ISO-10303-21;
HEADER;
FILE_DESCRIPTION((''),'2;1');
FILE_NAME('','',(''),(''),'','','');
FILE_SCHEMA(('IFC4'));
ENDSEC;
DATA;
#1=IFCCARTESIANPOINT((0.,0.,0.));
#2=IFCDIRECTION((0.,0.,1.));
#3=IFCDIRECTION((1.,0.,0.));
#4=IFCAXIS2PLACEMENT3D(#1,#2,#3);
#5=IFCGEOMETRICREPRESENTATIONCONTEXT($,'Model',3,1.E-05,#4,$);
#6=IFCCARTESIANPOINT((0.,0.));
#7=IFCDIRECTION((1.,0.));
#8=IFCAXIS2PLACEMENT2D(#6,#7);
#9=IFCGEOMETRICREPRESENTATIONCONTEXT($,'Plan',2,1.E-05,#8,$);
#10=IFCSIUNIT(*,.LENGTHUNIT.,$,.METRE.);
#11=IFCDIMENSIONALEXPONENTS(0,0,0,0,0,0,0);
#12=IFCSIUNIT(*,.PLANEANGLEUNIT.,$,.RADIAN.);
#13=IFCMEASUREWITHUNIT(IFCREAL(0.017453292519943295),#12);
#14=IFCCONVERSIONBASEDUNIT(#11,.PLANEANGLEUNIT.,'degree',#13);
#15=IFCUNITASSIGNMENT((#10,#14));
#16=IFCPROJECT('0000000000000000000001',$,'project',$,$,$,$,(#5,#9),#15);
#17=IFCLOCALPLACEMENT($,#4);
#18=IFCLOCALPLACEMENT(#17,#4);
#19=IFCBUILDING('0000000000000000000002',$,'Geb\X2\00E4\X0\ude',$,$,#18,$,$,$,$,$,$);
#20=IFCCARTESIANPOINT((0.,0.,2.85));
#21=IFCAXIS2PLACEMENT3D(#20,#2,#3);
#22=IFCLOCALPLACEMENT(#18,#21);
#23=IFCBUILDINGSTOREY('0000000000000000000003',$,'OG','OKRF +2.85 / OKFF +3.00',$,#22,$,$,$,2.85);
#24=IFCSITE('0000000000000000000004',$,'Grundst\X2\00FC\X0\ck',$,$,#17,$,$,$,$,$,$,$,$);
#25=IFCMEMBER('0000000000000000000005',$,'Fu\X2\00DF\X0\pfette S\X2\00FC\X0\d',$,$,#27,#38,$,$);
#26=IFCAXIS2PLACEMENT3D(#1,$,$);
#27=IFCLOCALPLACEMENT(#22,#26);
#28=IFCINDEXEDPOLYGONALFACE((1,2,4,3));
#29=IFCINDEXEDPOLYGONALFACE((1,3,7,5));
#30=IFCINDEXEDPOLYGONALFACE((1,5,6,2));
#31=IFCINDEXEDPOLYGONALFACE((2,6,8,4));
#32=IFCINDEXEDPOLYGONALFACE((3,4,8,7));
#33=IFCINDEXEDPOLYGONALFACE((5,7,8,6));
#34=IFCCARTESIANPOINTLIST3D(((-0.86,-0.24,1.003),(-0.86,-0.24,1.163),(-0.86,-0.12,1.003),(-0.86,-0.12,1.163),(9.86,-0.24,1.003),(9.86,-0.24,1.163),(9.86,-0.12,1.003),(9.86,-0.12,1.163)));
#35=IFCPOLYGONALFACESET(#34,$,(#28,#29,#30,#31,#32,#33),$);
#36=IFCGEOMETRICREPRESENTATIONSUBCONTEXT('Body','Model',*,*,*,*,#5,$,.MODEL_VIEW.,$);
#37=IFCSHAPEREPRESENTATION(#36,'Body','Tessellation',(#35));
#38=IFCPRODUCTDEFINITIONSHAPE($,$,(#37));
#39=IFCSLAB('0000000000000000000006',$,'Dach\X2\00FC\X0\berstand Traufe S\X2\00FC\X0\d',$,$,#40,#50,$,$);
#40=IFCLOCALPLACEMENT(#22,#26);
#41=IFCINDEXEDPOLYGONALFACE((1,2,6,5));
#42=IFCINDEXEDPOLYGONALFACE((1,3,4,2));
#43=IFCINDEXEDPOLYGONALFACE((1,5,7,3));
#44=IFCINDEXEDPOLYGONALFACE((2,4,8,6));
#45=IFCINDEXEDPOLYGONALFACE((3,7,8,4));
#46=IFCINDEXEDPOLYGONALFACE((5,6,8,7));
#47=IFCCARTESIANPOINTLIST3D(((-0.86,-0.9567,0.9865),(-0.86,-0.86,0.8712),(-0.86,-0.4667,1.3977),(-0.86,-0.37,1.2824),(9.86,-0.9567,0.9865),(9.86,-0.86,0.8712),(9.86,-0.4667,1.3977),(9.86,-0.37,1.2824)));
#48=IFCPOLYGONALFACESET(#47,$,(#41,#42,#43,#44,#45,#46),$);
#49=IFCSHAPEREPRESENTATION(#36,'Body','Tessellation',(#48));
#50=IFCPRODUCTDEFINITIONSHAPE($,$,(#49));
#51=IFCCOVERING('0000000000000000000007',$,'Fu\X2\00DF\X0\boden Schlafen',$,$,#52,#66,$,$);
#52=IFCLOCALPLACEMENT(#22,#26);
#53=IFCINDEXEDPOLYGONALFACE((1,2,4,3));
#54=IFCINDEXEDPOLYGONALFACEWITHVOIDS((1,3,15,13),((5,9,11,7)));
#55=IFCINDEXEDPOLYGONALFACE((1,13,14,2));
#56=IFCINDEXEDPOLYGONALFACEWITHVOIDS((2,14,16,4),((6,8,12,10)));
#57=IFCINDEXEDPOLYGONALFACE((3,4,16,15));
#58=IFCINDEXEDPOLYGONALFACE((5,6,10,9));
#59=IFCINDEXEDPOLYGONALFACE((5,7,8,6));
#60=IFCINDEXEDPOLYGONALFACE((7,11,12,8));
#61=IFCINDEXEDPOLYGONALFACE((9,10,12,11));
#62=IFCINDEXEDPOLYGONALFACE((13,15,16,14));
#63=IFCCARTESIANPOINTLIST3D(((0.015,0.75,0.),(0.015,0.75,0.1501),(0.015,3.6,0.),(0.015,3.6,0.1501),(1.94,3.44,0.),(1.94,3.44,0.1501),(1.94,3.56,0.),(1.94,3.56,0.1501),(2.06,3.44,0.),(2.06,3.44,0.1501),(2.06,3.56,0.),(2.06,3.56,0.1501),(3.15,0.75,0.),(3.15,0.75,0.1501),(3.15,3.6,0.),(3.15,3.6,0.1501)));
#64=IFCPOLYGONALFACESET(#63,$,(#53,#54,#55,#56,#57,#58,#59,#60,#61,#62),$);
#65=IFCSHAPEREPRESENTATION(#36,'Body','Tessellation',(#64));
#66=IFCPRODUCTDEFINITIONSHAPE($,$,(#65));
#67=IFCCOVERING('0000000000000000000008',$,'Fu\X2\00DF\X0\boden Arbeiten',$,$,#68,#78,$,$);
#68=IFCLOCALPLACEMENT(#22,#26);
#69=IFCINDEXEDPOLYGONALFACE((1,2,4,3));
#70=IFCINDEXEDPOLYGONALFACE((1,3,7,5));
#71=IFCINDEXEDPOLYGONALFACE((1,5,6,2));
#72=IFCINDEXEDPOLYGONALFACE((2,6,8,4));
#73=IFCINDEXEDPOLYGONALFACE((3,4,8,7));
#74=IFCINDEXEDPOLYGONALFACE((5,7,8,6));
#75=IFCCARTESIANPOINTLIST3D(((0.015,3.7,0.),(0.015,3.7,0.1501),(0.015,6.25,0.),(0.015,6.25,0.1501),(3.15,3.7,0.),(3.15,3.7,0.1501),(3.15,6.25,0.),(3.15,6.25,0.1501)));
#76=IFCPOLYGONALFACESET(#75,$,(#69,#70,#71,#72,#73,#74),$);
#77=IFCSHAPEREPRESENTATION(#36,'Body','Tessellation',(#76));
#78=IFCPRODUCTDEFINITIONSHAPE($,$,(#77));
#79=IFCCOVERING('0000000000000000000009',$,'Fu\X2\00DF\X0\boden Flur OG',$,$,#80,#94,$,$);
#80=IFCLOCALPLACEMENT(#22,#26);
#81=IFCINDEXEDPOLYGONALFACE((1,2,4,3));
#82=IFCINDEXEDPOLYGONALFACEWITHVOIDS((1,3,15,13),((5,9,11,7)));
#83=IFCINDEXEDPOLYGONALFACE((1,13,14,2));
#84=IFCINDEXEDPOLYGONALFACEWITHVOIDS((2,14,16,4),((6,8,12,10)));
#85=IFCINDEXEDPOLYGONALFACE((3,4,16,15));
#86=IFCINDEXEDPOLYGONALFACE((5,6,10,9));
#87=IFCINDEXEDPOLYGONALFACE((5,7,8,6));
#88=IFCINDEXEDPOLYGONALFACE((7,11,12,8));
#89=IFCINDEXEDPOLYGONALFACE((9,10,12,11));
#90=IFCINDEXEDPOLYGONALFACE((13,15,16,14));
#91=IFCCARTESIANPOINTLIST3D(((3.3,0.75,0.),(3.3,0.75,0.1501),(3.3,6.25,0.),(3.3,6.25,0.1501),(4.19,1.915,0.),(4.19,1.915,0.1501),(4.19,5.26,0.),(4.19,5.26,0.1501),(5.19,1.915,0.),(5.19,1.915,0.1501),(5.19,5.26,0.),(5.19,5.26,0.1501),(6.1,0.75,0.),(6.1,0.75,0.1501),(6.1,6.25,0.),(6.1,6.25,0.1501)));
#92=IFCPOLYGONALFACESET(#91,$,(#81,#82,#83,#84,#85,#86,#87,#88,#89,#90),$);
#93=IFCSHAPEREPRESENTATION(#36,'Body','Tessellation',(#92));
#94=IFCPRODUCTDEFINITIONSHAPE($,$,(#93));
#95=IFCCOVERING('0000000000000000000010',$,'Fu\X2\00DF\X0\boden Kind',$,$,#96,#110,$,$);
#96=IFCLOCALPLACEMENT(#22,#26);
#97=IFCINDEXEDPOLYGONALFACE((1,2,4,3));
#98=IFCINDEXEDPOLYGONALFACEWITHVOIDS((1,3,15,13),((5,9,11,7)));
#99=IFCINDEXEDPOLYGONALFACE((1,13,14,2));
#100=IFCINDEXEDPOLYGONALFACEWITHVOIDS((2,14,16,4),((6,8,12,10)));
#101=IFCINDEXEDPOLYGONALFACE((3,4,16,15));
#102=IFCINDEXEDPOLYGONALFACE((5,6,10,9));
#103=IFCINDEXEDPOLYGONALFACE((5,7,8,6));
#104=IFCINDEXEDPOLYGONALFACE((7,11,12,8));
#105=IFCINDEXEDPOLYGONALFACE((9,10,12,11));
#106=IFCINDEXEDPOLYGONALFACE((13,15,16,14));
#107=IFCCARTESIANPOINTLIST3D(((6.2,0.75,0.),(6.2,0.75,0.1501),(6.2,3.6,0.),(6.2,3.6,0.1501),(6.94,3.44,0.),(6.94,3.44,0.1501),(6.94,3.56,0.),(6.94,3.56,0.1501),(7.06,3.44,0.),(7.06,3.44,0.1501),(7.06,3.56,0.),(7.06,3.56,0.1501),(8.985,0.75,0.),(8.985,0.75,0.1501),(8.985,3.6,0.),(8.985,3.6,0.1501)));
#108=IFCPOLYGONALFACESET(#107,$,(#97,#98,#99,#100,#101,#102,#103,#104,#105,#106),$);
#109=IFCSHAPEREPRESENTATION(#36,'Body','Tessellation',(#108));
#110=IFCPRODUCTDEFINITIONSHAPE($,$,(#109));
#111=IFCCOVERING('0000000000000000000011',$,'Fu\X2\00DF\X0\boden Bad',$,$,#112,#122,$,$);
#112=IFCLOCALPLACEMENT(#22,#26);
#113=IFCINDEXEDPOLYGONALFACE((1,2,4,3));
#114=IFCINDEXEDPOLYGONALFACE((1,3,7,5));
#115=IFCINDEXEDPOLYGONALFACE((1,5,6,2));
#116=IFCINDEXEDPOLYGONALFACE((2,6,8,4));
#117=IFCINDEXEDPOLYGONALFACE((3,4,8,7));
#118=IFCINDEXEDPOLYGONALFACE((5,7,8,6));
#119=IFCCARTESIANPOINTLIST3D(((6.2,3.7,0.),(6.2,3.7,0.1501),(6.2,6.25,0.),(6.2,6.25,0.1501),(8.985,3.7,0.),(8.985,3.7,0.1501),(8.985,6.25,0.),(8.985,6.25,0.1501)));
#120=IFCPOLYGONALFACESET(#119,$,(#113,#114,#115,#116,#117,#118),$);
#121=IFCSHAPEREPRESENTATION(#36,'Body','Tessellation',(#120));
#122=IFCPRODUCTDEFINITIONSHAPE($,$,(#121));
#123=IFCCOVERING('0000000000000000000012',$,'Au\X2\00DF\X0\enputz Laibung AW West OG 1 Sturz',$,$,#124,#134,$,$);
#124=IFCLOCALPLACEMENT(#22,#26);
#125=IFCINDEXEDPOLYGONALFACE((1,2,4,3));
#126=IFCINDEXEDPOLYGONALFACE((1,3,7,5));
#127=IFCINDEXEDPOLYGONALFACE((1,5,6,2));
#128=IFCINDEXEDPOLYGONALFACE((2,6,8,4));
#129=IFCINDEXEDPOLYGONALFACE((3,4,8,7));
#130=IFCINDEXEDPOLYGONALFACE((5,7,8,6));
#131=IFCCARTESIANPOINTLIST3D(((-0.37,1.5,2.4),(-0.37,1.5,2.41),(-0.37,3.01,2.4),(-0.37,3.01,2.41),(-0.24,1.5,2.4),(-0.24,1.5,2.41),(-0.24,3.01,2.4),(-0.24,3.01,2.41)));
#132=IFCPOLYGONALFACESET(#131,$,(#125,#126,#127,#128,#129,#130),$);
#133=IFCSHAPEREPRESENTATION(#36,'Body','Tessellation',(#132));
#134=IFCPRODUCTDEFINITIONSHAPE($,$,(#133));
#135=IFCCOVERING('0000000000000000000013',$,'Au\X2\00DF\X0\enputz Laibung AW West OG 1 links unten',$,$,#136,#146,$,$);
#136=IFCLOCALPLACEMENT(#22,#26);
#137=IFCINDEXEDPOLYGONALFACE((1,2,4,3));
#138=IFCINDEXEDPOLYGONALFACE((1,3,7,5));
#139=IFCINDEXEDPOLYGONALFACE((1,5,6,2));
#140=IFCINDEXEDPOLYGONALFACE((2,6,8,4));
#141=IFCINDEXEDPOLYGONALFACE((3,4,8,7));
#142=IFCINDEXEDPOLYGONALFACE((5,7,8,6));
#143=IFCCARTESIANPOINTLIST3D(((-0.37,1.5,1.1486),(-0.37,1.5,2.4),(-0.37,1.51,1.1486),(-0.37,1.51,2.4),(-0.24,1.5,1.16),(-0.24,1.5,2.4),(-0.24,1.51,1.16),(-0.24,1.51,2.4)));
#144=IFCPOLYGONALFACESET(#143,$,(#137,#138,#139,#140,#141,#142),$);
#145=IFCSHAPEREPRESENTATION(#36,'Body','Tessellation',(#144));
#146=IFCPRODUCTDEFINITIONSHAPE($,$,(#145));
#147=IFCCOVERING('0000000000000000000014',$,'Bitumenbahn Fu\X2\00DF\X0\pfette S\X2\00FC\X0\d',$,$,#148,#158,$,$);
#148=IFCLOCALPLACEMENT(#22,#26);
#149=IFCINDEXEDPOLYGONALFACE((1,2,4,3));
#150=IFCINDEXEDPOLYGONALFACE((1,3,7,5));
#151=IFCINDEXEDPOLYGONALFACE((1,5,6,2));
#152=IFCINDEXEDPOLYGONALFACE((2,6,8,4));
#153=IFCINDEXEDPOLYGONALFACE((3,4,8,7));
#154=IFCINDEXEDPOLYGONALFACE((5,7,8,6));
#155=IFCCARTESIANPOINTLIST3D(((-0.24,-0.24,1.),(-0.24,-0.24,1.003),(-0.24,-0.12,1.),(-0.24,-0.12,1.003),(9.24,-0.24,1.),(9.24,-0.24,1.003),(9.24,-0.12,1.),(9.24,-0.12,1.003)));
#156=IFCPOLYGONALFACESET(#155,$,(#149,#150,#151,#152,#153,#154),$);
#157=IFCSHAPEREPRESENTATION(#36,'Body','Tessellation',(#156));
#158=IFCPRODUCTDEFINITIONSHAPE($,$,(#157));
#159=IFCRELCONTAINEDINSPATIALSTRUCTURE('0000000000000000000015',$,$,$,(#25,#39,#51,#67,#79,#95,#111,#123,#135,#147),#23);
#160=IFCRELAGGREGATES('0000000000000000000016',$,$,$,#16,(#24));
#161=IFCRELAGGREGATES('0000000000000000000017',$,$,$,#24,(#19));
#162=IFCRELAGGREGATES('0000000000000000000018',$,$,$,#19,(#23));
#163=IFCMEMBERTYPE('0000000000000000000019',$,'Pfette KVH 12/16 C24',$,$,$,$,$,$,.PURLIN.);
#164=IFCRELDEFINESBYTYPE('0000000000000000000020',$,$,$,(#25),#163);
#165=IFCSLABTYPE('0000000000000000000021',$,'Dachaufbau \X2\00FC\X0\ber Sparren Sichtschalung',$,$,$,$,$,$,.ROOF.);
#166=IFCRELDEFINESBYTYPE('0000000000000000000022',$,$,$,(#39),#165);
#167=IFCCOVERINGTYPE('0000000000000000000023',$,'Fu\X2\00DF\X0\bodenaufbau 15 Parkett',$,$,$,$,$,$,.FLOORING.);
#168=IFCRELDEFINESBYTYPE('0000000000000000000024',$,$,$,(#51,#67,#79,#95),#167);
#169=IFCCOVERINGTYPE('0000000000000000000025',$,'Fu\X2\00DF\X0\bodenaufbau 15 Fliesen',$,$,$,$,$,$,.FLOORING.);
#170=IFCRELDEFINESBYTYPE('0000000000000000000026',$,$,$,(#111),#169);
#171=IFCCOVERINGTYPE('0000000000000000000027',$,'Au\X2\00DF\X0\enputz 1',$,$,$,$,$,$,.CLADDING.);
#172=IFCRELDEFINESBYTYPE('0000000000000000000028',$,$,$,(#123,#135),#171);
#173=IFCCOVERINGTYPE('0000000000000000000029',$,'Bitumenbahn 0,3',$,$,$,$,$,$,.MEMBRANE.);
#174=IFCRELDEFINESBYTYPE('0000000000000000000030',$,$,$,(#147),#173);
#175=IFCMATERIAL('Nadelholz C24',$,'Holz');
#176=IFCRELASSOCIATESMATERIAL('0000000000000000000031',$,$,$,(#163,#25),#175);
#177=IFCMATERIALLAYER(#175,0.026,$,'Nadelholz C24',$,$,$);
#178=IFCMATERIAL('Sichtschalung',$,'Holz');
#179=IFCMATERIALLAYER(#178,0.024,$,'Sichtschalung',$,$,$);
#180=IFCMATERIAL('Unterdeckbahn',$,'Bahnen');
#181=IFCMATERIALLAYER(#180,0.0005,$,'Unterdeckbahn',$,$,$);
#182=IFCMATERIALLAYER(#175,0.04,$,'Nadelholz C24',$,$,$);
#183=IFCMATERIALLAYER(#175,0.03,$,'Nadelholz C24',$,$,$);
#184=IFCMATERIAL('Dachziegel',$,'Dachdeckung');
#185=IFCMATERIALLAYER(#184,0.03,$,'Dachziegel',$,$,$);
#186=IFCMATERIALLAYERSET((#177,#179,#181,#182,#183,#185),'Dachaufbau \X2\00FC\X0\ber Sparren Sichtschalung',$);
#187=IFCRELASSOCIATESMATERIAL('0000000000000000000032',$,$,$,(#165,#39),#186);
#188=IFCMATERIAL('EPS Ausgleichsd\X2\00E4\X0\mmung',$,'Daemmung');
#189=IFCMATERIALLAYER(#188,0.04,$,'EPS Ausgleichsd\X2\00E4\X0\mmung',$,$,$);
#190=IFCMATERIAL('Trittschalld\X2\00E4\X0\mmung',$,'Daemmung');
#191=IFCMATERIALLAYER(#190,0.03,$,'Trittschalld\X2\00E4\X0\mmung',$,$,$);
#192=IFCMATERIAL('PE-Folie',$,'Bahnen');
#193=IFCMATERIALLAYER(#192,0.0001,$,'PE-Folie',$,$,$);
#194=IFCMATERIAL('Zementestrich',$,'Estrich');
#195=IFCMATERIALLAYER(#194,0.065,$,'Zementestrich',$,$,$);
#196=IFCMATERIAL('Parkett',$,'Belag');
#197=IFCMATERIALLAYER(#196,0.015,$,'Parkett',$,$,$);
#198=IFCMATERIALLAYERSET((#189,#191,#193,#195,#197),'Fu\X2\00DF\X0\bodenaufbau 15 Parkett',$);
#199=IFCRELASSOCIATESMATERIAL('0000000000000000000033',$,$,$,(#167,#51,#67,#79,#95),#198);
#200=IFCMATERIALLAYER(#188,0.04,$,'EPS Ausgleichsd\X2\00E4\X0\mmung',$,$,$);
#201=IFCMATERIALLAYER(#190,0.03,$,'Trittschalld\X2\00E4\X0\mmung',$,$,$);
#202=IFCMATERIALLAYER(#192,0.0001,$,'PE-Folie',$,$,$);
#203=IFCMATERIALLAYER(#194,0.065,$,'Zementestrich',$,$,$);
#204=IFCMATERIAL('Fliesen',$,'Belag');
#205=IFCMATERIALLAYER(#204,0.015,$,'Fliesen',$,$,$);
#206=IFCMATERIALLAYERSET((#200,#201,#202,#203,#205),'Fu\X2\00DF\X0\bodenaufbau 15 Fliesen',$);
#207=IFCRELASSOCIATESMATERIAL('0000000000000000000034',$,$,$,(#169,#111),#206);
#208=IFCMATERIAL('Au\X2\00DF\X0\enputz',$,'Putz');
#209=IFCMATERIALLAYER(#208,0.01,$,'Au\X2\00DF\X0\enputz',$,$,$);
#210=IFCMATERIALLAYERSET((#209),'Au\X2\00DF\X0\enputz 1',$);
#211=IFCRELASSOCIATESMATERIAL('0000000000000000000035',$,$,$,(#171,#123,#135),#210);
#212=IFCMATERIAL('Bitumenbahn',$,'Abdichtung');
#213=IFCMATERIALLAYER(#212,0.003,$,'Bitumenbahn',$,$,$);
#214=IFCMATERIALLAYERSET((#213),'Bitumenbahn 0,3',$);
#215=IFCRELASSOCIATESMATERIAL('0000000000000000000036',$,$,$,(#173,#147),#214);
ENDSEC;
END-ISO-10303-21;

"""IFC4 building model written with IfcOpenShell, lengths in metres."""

from ifc_helpers import new_model, entity, si_unit, converted_unit, frame, origin_with_axes, origin_2d_with_axis, place, context, subcontext, project, spatial, polyline, indexed_curve, rectangle, outline, extrude, clip, halfspace, material, layer, layer_set, layer_usage, material_profile, profile_set, profile_usage, type_object, element, save


model = new_model("IFC4")

# Units and contexts
model_context = context("Model", 3, precision=1e-05, world=origin_with_axes())
plan_context = context("Plan", 2, precision=1e-05, world=origin_2d_with_axis())
body_context_1 = subcontext(model_context, "Body", "Model", "MODEL_VIEW")
ifc_project = project(units=[si_unit("LENGTHUNIT", "METRE"), converted_unit("PLANEANGLEUNIT", "degree", entity("IfcReal", 0.017453292519943295), si_unit("PLANEANGLEUNIT", "RADIAN"), dimensions=[0, 0, 0, 0, 0, 0, 0])], contexts=[model_context, plan_context])

# Site, building, storey
site_placement = place(None, origin_with_axes())
site = spatial("IfcSite", under=ifc_project, at=site_placement, Name="Grundstück")
building_placement = place(site_placement, origin_with_axes())
building = spatial("IfcBuilding", under=site, at=building_placement, Name="Gebäude")
storey_placement = place(building_placement, frame((0.0, 0.0, 2.85), z_axis=(0.0, 0.0, 1.0), x_axis=(1.0, 0.0, 0.0)))
storey = spatial("IfcBuildingStorey", under=building, at=storey_placement, Name="OG", Description="OKRF +2.85 / OKFF +3.00", Elevation=2.85)

# Shared definitions
ifc_material_1 = material(Name="Nadelholz C24", Category="Holz")

# Member
ifc_material_profile_1 = material_profile(ifc_material_1, rectangle(XDim=0.12, YDim=0.16))
ifc_profile_set_1 = profile_set([ifc_material_profile_1], Name="Pfette KVH 12/16 C24")
ifc_profile_usage_1 = profile_usage(ifc_profile_set_1)
member_type_1 = type_object("IfcMemberType", Name="Pfette KVH 12/16 C24", PredefinedType="PURLIN", material=ifc_profile_set_1)
member_1_placement = place(storey_placement, frame((-0.86, -0.18, 1.083), z_axis=(1.0, 0.0, 0.0), x_axis=(0.0, 1.0, 0.0)))
element("IfcMember", 1, at=member_1_placement, inside=storey, type_object=member_type_1, material=ifc_profile_usage_1, Name="Fußpfette Süd", context=body_context_1, shape_type="SweptSolid", body=[
    extrude(rectangle(XDim=0.12, YDim=0.16), origin_with_axes(), (0.0, 0.0, 1.0), 10.72),
])

# Slab
ifc_material_2 = material(Name="Unterdeckbahn", Category="Bahnen")
ifc_material_3 = material(Name="Dachziegel", Category="Dachdeckung")
ifc_layer_1 = layer(ifc_material_1, 0.026, Name="Nadelholz C24")
ifc_material_4 = material(Name="Sichtschalung", Category="Holz")
ifc_layer_2 = layer(ifc_material_4, 0.024, Name="Sichtschalung")
ifc_layer_3 = layer(ifc_material_2, 0.0005, Name="Unterdeckbahn")
ifc_layer_4 = layer(ifc_material_1, 0.04, Name="Nadelholz C24")
ifc_layer_5 = layer(ifc_material_1, 0.03, Name="Nadelholz C24")
ifc_layer_6 = layer(ifc_material_3, 0.03, Name="Dachziegel")
ifc_layer_set_1 = layer_set([ifc_layer_1, ifc_layer_2, ifc_layer_3, ifc_layer_4, ifc_layer_5, ifc_layer_6], Name="Dachaufbau über Sparren Sichtschalung")
ifc_layer_usage_1 = layer_usage(ifc_layer_set_1, "AXIS3", "POSITIVE", 0.0)
slab_type_1 = type_object("IfcSlabType", Name="Dachaufbau über Sparren Sichtschalung", PredefinedType="ROOF", material=ifc_layer_set_1)
slab_1_placement = place(storey_placement, frame((-0.86, -0.86, 0.8712), z_axis=(0.0, -0.642788, 0.766044), x_axis=(1.0, 0.0, 0.0)))
element("IfcSlab", 2, at=slab_1_placement, inside=storey, type_object=slab_type_1, material=ifc_layer_usage_1, Name="Dachüberstand Traufe Süd", context=body_context_1, shape_type="Clipping", body=[
    clip(extrude(outline(indexed_curve([(0.0, 0.0), (10.72, 0.0), (10.72, 0.6396), (0.0, 0.6396)])), None, (0.0, 0.0, 1.0), 0.1505), halfspace(frame((0.86, 0.948, -5.6532), z_axis=(0.0, 0.766044, -0.642788), x_axis=(1.0, 0.0, 0.0)), False)),
])

# Covering, opening
ifc_material_5 = material(Name="EPS Ausgleichsdämmung", Category="Daemmung")
ifc_layer_7 = layer(ifc_material_5, 0.04, Name="EPS Ausgleichsdämmung")
ifc_material_6 = material(Name="Trittschalldämmung", Category="Daemmung")
ifc_layer_8 = layer(ifc_material_6, 0.03, Name="Trittschalldämmung")
ifc_material_7 = material(Name="PE-Folie", Category="Bahnen")
ifc_layer_9 = layer(ifc_material_7, 0.0001, Name="PE-Folie")
ifc_material_8 = material(Name="Zementestrich", Category="Estrich")
ifc_layer_10 = layer(ifc_material_8, 0.065, Name="Zementestrich")
ifc_material_9 = material(Name="Parkett", Category="Belag")
ifc_layer_11 = layer(ifc_material_9, 0.015, Name="Parkett")
ifc_layer_set_2 = layer_set([ifc_layer_7, ifc_layer_8, ifc_layer_9, ifc_layer_10, ifc_layer_11], Name="Fußbodenaufbau 15 Parkett")
ifc_layer_usage_2 = layer_usage(ifc_layer_set_2, "AXIS3", "POSITIVE", 0.0)
covering_type_1 = type_object("IfcCoveringType", Name="Fußbodenaufbau 15 Parkett", PredefinedType="FLOORING", material=ifc_layer_set_2)
covering_1_placement = place(storey_placement, origin_with_axes())
covering_1 = element("IfcCovering", 3, at=covering_1_placement, inside=storey, type_object=covering_type_1, material=ifc_layer_usage_2, Name="Fußboden Schlafen", context=body_context_1, shape_type="SweptSolid", body=[
    extrude(outline(indexed_curve([(0.015, 0.75), (3.15, 0.75), (3.15, 3.6), (0.015, 3.6)])), None, (0.0, 0.0, 1.0), 0.1501),
])
opening_1_placement = place(covering_1_placement, frame((1.94, 3.44, -0.05), z_axis=(0.0, 0.0, 1.0), x_axis=(1.0, 0.0, 0.0)))
element("IfcOpeningElement", 4, at=opening_1_placement, cuts=covering_1, context=body_context_1, shape_type="SweptSolid", body=[
    extrude(outline(indexed_curve([(0.0, 0.0), (0.0, 0.12), (0.12, 0.12), (0.12, 0.0), (0.0, 0.0)], self_intersect=False)), origin_with_axes(), (0.0, 0.0, 1.0), 0.2501),
])

# Covering
ifc_layer_usage_3 = layer_usage(ifc_layer_set_2, "AXIS3", "POSITIVE", 0.0)
covering_2_placement = place(storey_placement, origin_with_axes())
element("IfcCovering", 5, at=covering_2_placement, inside=storey, type_object=covering_type_1, material=ifc_layer_usage_3, Name="Fußboden Arbeiten", context=body_context_1, shape_type="SweptSolid", body=[
    extrude(outline(indexed_curve([(0.015, 3.7), (3.15, 3.7), (3.15, 6.25), (0.015, 6.25)])), None, (0.0, 0.0, 1.0), 0.1501),
])

# Coverings, openings
ifc_layer_usage_4 = layer_usage(ifc_layer_set_2, "AXIS3", "POSITIVE", 0.0)
covering_3_placement = place(storey_placement, origin_with_axes())
covering_3 = element("IfcCovering", 6, at=covering_3_placement, inside=storey, type_object=covering_type_1, material=ifc_layer_usage_4, Name="Fußboden Flur OG", context=body_context_1, shape_type="SweptSolid", body=[
    extrude(outline(indexed_curve([(3.3, 0.75), (6.1, 0.75), (6.1, 6.25), (3.3, 6.25)])), None, (0.0, 0.0, 1.0), 0.1501),
])
opening_2_placement = place(covering_3_placement, frame((4.19, 1.915, -0.05), z_axis=(0.0, 0.0, 1.0), x_axis=(1.0, 0.0, 0.0)))
element("IfcOpeningElement", 7, at=opening_2_placement, cuts=covering_3, context=body_context_1, shape_type="SweptSolid", body=[
    extrude(outline(indexed_curve([(0.0, 0.0), (0.0, 3.345), (1.0, 3.345), (1.0, 0.0), (0.0, 0.0)], self_intersect=False)), origin_with_axes(), (0.0, 0.0, 1.0), 0.2501),
])
ifc_layer_usage_5 = layer_usage(ifc_layer_set_2, "AXIS3", "POSITIVE", 0.0)
covering_4_placement = place(storey_placement, origin_with_axes())
covering_4 = element("IfcCovering", 8, at=covering_4_placement, inside=storey, type_object=covering_type_1, material=ifc_layer_usage_5, Name="Fußboden Kind", context=body_context_1, shape_type="SweptSolid", body=[
    extrude(outline(indexed_curve([(6.2, 0.75), (8.985, 0.75), (8.985, 3.6), (6.2, 3.6)])), None, (0.0, 0.0, 1.0), 0.1501),
])
opening_3_placement = place(covering_4_placement, frame((6.94, 3.44, -0.05), z_axis=(0.0, 0.0, 1.0), x_axis=(1.0, 0.0, 0.0)))
element("IfcOpeningElement", 9, at=opening_3_placement, cuts=covering_4, context=body_context_1, shape_type="SweptSolid", body=[
    extrude(outline(indexed_curve([(0.0, 0.0), (0.0, 0.12), (0.12, 0.12), (0.12, 0.0), (0.0, 0.0)], self_intersect=False)), origin_with_axes(), (0.0, 0.0, 1.0), 0.2501),
])

# Coverings
ifc_layer_12 = layer(ifc_material_5, 0.04, Name="EPS Ausgleichsdämmung")
ifc_layer_13 = layer(ifc_material_6, 0.03, Name="Trittschalldämmung")
ifc_layer_14 = layer(ifc_material_7, 0.0001, Name="PE-Folie")
ifc_layer_15 = layer(ifc_material_8, 0.065, Name="Zementestrich")
ifc_material_10 = material(Name="Fliesen", Category="Belag")
ifc_layer_16 = layer(ifc_material_10, 0.015, Name="Fliesen")
ifc_layer_set_3 = layer_set([ifc_layer_12, ifc_layer_13, ifc_layer_14, ifc_layer_15, ifc_layer_16], Name="Fußbodenaufbau 15 Fliesen")
ifc_layer_usage_6 = layer_usage(ifc_layer_set_3, "AXIS3", "POSITIVE", 0.0)
covering_type_2 = type_object("IfcCoveringType", Name="Fußbodenaufbau 15 Fliesen", PredefinedType="FLOORING", material=ifc_layer_set_3)
covering_5_placement = place(storey_placement, origin_with_axes())
element("IfcCovering", 10, at=covering_5_placement, inside=storey, type_object=covering_type_2, material=ifc_layer_usage_6, Name="Fußboden Bad", context=body_context_1, shape_type="SweptSolid", body=[
    extrude(outline(indexed_curve([(6.2, 3.7), (8.985, 3.7), (8.985, 6.25), (6.2, 6.25)])), None, (0.0, 0.0, 1.0), 0.1501),
])
ifc_material_11 = material(Name="Außenputz", Category="Putz")
ifc_layer_17 = layer(ifc_material_11, 0.01, Name="Außenputz")
ifc_layer_set_4 = layer_set([ifc_layer_17], Name="Außenputz 1")
ifc_layer_usage_7 = layer_usage(ifc_layer_set_4, "AXIS3", "POSITIVE", 2.4)
covering_type_3 = type_object("IfcCoveringType", Name="Außenputz 1", PredefinedType="CLADDING", material=ifc_layer_set_4)
covering_6_placement = place(storey_placement, frame((0.0, 0.0, 0.0), z_axis=(0.0, 0.0, 1.0), x_axis=(0.0, 1.0, 0.0)))
element("IfcCovering", 11, at=covering_6_placement, inside=storey, type_object=covering_type_3, material=ifc_layer_usage_7, Name="Außenputz Laibung AW West OG 1 Sturz", context=body_context_1, shape_type="SweptSolid", body=[
    extrude(outline(polyline([(0.24, 2.4), (0.37, 2.4), (0.37, 2.41), (0.24, 2.41), (0.24, 2.4)])), frame((1.5, 0.0, 0.0), z_axis=(1.0, 0.0, 0.0), x_axis=(0.0, 1.0, 0.0)), (0.0, 0.0, 1.0), 1.51),
])
ifc_layer_usage_8 = layer_usage(ifc_layer_set_4, "AXIS1", "POSITIVE", 1.5)
covering_7_placement = place(storey_placement, frame((0.0, 0.0, 0.0), z_axis=(0.0, 0.0, 1.0), x_axis=(0.0, 1.0, 0.0)))
element("IfcCovering", 12, at=covering_7_placement, inside=storey, type_object=covering_type_3, material=ifc_layer_usage_8, Name="Außenputz Laibung AW West OG 1 links unten", context=body_context_1, shape_type="SweptSolid", body=[
    extrude(outline(polyline([(0.24, 1.16), (0.37, 1.1486), (0.37, 2.4), (0.24, 2.4), (0.24, 1.16)])), frame((1.5, 0.0, 0.0), z_axis=(1.0, 0.0, 0.0), x_axis=(0.0, 1.0, 0.0)), (0.0, 0.0, 1.0), 0.01),
])
ifc_material_12 = material(Name="Bitumenbahn", Category="Abdichtung")
ifc_layer_18 = layer(ifc_material_12, 0.003, Name="Bitumenbahn")
ifc_layer_set_5 = layer_set([ifc_layer_18], Name="Bitumenbahn 0,3")
ifc_layer_usage_9 = layer_usage(ifc_layer_set_5, "AXIS3", "POSITIVE", 0.0)
covering_type_4 = type_object("IfcCoveringType", Name="Bitumenbahn 0,3", PredefinedType="MEMBRANE", material=ifc_layer_set_5)
covering_8_placement = place(storey_placement, frame((0.0, 0.0, 1.0), z_axis=(0.0, 0.0, 1.0), x_axis=(1.0, 0.0, 0.0)))
element("IfcCovering", 13, at=covering_8_placement, inside=storey, type_object=covering_type_4, material=ifc_layer_usage_9, Name="Bitumenbahn Fußpfette Süd", context=body_context_1, shape_type="SweptSolid", body=[
    extrude(outline(indexed_curve([(-0.24, -0.24), (9.24, -0.24), (9.24, -0.12), (-0.24, -0.12)])), None, (0.0, 0.0, 1.0), 0.003),
])

save(model, "model.ifc")
